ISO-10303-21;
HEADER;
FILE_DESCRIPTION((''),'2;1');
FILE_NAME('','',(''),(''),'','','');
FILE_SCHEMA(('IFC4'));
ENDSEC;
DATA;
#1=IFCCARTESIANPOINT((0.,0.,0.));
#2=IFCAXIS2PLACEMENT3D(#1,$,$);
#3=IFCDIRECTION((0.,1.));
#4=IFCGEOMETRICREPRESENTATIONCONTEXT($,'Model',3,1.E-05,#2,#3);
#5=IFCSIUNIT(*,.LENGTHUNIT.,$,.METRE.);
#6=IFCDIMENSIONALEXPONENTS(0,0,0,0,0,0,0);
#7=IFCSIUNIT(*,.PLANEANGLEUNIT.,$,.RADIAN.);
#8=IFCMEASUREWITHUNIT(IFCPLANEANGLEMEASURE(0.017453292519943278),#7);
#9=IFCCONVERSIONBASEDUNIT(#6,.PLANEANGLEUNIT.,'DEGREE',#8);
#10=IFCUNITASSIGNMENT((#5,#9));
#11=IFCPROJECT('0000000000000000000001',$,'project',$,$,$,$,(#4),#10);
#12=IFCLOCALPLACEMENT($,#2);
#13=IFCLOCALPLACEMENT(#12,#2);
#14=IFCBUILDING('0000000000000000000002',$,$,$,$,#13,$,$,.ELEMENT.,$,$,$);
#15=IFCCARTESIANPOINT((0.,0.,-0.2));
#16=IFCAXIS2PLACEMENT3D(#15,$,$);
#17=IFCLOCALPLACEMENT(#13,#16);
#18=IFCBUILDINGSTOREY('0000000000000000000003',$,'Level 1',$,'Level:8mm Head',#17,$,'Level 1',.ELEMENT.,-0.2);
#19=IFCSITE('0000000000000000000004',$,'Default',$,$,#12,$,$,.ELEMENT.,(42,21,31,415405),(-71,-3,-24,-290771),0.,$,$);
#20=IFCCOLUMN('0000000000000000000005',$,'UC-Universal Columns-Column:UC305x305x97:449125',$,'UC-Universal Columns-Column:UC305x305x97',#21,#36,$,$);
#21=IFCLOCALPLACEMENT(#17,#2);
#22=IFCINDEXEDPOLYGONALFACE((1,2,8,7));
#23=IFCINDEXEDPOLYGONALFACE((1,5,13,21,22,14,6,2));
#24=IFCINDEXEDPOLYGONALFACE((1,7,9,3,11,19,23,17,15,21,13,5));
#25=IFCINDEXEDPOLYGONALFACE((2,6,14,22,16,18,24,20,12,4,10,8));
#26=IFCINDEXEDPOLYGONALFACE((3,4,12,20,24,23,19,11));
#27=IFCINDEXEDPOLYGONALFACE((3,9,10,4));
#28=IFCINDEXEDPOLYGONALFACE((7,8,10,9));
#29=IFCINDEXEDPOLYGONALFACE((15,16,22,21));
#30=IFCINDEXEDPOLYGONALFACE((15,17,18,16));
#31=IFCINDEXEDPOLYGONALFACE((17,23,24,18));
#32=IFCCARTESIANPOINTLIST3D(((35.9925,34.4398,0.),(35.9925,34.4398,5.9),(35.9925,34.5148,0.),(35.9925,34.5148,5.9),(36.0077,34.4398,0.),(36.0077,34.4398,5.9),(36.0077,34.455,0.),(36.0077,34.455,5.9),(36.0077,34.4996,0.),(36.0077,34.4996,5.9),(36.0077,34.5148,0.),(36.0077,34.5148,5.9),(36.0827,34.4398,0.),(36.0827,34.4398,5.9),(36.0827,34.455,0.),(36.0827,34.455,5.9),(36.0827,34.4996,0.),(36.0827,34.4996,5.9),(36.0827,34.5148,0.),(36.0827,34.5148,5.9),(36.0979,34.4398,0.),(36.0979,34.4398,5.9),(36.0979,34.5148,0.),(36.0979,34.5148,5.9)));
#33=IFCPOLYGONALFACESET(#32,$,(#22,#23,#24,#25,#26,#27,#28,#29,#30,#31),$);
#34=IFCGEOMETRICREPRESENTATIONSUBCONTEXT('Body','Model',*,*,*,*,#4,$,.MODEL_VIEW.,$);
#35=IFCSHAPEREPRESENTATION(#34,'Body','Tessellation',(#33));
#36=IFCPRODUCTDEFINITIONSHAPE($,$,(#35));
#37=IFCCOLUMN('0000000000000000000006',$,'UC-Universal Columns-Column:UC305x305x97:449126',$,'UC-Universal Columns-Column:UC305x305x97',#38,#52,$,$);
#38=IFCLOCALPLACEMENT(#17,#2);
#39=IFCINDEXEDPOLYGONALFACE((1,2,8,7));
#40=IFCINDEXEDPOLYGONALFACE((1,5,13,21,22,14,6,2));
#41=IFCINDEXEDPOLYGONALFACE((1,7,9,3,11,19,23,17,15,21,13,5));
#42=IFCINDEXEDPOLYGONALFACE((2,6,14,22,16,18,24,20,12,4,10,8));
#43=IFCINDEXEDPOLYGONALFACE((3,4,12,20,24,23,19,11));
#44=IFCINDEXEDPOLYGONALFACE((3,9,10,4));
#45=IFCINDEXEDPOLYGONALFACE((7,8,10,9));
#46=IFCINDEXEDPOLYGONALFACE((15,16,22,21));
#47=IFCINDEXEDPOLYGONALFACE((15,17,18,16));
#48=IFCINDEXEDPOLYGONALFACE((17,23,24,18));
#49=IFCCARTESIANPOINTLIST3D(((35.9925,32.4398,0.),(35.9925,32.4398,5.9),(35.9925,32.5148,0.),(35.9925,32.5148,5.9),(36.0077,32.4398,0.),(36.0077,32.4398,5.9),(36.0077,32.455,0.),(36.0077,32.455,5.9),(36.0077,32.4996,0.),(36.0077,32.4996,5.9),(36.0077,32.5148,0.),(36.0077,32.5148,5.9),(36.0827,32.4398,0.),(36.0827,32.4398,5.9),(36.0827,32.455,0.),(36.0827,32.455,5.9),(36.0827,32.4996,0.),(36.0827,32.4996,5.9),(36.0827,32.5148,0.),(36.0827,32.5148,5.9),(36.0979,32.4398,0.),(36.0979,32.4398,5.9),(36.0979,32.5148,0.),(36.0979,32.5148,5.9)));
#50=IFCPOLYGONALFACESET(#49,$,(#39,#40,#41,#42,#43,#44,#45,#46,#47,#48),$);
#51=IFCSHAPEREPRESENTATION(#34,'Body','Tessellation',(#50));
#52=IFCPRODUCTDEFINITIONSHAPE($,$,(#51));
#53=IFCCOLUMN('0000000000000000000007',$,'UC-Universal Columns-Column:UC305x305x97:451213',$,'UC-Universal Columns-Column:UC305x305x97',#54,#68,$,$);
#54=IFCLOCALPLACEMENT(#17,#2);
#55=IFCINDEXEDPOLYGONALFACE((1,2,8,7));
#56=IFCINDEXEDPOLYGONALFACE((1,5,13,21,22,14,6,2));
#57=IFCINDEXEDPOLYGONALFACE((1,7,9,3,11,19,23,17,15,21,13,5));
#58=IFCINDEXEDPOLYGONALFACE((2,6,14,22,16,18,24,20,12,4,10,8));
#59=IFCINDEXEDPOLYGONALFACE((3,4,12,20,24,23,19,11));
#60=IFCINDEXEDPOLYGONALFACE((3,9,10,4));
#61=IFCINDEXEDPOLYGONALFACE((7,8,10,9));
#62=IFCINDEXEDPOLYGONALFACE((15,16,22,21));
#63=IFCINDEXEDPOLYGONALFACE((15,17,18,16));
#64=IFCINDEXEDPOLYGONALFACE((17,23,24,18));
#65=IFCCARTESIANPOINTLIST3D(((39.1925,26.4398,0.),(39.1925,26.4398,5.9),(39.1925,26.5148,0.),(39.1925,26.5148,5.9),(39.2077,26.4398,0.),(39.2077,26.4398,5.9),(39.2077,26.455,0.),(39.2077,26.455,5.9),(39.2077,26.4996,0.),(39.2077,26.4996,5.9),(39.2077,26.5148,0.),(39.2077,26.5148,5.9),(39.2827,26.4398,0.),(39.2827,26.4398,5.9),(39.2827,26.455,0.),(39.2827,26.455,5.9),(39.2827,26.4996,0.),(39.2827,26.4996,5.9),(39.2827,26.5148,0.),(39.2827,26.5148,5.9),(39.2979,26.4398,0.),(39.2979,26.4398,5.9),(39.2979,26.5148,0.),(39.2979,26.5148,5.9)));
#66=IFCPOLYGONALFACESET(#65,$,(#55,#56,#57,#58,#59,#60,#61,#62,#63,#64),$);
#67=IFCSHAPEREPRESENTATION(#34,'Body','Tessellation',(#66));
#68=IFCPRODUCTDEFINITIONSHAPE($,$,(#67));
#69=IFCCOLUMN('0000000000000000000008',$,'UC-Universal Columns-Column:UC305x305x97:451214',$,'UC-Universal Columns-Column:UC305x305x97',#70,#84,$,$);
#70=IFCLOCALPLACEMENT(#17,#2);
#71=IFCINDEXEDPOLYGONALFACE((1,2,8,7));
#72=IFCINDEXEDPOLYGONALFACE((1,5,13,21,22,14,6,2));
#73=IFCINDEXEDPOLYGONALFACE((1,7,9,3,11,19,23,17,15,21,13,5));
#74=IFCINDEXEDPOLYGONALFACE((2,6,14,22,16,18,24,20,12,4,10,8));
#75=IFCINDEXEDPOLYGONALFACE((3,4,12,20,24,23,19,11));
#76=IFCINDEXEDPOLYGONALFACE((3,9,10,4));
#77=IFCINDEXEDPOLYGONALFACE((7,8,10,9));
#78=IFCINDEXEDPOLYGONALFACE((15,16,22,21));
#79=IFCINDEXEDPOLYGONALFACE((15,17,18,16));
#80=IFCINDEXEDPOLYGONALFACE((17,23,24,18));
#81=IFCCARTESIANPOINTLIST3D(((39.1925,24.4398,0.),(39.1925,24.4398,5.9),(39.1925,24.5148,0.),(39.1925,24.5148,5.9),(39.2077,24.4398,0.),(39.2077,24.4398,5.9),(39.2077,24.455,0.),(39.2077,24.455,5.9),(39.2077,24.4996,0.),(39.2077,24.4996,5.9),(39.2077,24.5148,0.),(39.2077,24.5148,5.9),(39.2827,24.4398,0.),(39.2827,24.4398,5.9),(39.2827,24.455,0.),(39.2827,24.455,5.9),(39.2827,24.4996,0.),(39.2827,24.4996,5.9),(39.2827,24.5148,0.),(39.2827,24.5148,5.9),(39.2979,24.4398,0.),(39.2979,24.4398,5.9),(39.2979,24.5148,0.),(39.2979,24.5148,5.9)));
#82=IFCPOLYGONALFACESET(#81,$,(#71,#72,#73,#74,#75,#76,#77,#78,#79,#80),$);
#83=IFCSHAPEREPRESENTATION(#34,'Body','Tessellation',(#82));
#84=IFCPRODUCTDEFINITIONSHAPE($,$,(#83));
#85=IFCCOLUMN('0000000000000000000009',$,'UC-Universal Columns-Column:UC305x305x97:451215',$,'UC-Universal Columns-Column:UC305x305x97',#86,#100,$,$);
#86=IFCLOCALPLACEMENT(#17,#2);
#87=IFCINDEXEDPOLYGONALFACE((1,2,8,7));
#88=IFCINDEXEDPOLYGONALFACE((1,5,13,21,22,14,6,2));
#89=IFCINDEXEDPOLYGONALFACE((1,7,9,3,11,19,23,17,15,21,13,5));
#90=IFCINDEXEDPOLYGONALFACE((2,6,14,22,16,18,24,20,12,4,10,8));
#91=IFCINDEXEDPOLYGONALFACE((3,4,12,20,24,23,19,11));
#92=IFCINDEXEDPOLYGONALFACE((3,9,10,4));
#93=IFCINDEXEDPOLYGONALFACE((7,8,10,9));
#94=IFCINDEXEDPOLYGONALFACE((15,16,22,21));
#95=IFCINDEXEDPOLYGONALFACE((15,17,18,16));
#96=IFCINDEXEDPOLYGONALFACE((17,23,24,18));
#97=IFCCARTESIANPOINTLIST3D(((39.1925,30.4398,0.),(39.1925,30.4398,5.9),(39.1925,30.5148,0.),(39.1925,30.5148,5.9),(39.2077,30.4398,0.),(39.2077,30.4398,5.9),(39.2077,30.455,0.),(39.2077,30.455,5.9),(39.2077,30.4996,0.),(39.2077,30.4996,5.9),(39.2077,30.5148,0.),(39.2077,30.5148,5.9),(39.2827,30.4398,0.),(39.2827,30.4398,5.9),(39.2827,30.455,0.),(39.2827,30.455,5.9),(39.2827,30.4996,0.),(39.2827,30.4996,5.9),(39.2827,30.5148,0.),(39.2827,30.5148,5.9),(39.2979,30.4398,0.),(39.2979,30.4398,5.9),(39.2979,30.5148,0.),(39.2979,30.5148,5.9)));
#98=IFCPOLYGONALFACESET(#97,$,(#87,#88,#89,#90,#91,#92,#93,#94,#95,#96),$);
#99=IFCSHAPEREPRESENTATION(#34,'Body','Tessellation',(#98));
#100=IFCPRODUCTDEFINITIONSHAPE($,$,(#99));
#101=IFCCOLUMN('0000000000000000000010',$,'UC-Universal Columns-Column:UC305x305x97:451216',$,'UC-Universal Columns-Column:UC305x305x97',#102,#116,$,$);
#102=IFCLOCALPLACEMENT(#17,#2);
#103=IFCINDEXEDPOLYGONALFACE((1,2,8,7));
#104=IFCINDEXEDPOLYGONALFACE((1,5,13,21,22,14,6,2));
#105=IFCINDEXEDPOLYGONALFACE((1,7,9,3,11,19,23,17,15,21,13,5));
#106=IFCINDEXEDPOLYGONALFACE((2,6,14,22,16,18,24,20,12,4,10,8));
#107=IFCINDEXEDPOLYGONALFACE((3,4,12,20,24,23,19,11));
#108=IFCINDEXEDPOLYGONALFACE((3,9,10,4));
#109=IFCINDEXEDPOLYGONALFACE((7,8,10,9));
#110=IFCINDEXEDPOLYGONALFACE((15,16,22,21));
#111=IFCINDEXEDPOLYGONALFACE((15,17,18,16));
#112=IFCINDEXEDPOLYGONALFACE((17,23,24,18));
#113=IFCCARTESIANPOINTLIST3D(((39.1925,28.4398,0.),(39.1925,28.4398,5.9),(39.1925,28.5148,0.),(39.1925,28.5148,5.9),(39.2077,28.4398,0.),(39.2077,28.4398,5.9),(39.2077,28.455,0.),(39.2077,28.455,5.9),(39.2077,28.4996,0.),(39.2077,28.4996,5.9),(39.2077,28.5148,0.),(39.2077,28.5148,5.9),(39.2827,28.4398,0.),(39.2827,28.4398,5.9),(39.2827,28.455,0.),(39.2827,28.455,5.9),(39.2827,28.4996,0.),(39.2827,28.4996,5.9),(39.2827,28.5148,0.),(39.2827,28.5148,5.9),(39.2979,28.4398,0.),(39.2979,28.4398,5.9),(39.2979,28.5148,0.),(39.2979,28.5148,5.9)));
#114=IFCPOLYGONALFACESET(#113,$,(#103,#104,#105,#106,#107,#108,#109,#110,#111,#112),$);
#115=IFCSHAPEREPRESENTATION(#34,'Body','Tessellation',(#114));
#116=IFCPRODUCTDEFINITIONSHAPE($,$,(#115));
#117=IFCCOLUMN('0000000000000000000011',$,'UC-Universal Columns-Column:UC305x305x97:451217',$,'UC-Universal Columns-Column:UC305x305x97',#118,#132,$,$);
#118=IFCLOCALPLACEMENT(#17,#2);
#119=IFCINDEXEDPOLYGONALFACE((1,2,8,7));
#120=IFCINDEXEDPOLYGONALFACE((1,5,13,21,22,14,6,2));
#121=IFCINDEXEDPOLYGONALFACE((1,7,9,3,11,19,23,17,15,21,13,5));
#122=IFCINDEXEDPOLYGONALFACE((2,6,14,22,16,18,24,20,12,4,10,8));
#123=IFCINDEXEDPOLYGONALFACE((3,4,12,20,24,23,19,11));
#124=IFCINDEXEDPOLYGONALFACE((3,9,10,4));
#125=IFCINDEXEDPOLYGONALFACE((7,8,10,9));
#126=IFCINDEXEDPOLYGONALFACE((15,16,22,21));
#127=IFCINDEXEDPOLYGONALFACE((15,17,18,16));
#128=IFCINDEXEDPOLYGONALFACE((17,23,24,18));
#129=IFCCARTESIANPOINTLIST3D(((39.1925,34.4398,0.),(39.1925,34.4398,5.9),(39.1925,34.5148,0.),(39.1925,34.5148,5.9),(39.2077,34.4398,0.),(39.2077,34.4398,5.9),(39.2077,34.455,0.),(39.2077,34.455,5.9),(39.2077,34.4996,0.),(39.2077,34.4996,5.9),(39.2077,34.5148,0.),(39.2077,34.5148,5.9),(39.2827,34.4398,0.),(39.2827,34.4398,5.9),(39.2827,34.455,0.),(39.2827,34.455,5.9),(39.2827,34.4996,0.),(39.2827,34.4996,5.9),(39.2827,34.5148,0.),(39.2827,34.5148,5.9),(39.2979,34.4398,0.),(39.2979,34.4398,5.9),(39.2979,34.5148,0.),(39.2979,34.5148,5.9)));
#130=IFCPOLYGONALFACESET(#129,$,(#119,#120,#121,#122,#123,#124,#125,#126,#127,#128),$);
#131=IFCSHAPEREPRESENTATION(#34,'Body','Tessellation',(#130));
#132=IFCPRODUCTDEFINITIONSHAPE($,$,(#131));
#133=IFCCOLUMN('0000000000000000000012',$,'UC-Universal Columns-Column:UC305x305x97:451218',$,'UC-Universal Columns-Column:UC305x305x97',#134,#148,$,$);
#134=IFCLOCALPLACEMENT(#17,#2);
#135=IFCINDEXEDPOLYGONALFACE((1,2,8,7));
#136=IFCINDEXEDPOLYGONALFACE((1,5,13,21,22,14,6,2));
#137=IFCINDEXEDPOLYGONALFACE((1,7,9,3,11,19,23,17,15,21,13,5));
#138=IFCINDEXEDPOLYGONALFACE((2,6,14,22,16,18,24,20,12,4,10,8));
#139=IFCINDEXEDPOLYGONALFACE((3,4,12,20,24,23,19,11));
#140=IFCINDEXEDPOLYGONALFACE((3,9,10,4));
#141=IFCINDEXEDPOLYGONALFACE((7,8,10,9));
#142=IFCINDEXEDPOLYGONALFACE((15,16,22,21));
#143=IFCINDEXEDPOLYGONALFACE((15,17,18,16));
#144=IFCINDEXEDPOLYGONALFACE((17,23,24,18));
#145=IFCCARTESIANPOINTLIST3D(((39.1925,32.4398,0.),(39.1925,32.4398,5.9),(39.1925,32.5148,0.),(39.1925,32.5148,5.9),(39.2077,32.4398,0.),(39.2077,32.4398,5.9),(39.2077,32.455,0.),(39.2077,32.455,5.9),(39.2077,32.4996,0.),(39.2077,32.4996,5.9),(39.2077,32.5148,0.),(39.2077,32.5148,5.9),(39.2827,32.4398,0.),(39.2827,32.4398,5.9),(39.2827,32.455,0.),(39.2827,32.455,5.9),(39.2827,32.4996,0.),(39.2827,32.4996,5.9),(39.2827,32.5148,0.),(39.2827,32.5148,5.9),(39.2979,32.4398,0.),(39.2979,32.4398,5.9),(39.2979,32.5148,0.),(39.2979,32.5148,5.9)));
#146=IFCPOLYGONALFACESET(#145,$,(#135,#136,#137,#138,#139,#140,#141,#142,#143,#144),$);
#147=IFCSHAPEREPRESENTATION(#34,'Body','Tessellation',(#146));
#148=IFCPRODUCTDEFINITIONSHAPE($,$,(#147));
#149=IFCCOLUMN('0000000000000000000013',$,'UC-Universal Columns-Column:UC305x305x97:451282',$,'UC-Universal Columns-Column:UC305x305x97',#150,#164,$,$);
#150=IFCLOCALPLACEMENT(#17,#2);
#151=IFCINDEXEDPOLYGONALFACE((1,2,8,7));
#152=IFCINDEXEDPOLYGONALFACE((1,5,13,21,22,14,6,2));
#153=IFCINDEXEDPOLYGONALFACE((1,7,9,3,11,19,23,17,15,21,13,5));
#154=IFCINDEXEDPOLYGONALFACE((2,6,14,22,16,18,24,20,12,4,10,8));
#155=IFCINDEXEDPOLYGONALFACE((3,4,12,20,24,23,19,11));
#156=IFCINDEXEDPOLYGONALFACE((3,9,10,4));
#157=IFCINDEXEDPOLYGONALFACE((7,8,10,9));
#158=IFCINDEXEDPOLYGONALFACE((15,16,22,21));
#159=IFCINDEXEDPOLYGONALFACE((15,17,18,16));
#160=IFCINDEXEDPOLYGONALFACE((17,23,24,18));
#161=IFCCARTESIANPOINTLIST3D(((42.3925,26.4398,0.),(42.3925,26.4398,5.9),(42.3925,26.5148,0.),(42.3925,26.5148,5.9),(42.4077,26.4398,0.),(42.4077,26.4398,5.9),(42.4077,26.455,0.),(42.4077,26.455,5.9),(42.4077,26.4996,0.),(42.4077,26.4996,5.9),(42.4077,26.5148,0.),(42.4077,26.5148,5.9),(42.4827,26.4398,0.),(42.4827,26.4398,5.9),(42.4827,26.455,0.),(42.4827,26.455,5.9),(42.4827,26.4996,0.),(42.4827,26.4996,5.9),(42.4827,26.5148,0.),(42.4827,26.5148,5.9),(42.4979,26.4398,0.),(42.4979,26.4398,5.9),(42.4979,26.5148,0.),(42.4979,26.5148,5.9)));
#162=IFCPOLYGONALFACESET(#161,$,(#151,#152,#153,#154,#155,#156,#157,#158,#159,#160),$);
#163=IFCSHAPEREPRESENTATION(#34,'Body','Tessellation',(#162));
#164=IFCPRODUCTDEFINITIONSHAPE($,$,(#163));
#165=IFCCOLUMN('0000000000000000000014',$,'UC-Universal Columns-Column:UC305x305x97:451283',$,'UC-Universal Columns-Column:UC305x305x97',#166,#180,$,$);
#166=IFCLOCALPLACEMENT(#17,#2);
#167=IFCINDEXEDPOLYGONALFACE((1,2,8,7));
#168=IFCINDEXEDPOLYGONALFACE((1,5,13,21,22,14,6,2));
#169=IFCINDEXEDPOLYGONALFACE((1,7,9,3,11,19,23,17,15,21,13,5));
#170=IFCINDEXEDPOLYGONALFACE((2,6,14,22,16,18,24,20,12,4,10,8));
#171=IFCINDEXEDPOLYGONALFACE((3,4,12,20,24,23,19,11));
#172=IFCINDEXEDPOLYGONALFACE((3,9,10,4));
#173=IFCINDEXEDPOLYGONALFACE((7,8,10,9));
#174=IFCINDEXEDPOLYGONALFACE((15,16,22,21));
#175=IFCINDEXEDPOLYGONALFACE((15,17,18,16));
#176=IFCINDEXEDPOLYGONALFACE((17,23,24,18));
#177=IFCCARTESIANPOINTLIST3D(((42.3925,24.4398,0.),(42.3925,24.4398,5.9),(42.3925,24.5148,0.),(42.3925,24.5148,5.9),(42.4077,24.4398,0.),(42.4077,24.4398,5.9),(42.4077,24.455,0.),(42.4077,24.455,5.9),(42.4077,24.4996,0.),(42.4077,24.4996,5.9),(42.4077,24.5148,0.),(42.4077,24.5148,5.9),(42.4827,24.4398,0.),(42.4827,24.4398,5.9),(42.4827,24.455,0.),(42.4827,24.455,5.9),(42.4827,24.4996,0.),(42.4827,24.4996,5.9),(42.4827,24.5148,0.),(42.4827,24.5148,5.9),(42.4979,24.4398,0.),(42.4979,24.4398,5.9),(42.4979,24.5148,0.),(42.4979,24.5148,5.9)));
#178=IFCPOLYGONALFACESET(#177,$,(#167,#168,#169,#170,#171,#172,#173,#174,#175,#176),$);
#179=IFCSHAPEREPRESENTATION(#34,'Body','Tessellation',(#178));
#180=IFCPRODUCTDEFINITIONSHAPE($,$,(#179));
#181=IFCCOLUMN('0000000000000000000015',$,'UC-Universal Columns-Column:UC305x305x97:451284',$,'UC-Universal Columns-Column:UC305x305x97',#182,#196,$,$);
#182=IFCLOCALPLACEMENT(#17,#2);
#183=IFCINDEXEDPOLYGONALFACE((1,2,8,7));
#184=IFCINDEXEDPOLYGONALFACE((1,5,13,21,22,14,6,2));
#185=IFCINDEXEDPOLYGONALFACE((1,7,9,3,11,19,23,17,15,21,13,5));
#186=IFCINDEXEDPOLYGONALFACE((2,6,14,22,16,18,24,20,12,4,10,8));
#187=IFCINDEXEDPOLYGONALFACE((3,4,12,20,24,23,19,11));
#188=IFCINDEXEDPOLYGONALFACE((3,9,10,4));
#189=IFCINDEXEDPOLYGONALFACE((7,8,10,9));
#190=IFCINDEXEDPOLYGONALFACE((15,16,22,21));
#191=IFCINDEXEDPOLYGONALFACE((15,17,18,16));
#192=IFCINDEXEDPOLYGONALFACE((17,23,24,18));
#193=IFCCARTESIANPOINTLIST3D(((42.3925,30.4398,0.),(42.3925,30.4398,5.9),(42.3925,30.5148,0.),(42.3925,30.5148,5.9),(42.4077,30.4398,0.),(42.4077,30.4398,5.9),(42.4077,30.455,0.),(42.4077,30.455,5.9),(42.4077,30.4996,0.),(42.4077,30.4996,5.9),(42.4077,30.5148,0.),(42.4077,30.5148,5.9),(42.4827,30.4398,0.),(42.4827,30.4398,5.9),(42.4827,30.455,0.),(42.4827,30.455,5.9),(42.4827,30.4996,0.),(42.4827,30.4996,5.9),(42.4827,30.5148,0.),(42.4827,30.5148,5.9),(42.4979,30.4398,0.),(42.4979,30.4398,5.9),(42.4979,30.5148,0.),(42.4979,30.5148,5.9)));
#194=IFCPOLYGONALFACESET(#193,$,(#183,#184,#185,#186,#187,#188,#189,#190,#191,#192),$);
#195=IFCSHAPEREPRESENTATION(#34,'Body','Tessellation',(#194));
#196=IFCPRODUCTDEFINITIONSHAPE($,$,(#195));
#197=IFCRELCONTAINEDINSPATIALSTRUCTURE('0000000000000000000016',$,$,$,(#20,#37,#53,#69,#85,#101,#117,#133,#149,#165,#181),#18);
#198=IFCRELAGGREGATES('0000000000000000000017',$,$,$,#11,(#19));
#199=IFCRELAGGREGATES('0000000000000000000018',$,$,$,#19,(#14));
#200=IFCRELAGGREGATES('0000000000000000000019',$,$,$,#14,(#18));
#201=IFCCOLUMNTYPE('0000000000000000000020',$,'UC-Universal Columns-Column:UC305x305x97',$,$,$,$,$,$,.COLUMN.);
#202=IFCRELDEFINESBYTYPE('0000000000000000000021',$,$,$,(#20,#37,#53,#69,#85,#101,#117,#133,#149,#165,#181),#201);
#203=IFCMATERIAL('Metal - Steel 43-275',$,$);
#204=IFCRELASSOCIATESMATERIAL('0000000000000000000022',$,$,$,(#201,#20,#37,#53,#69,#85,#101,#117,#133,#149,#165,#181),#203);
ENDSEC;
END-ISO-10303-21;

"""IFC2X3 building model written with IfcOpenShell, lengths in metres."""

from ifc_helpers import new_model, entity, si_unit, converted_unit, direction, frame, frame_2d, origin, place, context, subcontext, project, spatial, polyline, circle_curve, parameter, trimmed, segment, composite_curve, outline, extrude, source, transform, mapped, material, type_object, type_shapes, element, save


model = new_model("IFC2X3")

# Units and contexts
model_context = context("Model", 3, precision=1e-05, world=origin(), true_north=direction((0.0, 1.0)))
body_context = subcontext(model_context, "Body", "Model", "MODEL_VIEW")
ifc_project = project(units=[si_unit("LENGTHUNIT", "METRE"), converted_unit("PLANEANGLEUNIT", "DEGREE", entity("IfcPlaneAngleMeasure", 0.017453292519943278), si_unit("PLANEANGLEUNIT", "RADIAN"), dimensions=[0, 0, 0, 0, 0, 0, 0])], contexts=[model_context])

# Site, building, storey
site_placement = place(None, origin())
site = spatial("IfcSite", under=ifc_project, at=site_placement, Name="Default", CompositionType="ELEMENT", RefLatitude=(42, 21, 31, 415405), RefLongitude=(-71, -3, -24, -290771), RefElevation=0.0)
building_placement = place(site_placement, origin())
building = spatial("IfcBuilding", under=site, at=building_placement, CompositionType="ELEMENT")
storey_placement = place(building_placement, frame((0.0, 0.0, -0.2)))
storey = spatial("IfcBuildingStorey", under=building, at=storey_placement, Name="Level 1", ObjectType="Level:8mm Head", LongName="Level 1", CompositionType="ELEMENT", Elevation=-0.2)

# Columns
ifc_material = material(Name="Metal - Steel 43-275")
column_type = type_object("IfcColumnType", Name="UC-Universal Columns-Column:UC305x305x97", PredefinedType="COLUMN", material=ifc_material)
shared_shape = source(origin(), body_context, "Body", "SweptSolid", [
    extrude(outline(composite_curve([segment(polyline([(-0.0375, -0.0375), (0.0375, -0.0375)]), True, "CONTINUOUS"), segment(polyline([(0.0375, -0.0375), (0.0527, -0.0375)]), True, "CONTINUOUS"), segment(trimmed(circle_curve(frame_2d((0.0527, -0.0223), x_axis=(-1.0, 0.0)), 0.0152), [parameter(0.0)], [parameter(90.0)], True, "PARAMETER"), False, "CONTINUOUS"), segment(polyline([(0.0375, -0.0223), (0.0375, 0.0223)]), True, "CONTINUOUS"), segment(trimmed(circle_curve(frame_2d((0.0527, 0.0223), x_axis=(-1.0, 0.0)), 0.0152), [parameter(270.0)], [parameter(0.0)], True, "PARAMETER"), False, "CONTINUOUS"), segment(polyline([(0.0527, 0.0375), (0.0375, 0.0375)]), True, "CONTINUOUS"), segment(polyline([(0.0375, 0.0375), (-0.0375, 0.0375)]), True, "CONTINUOUS"), segment(polyline([(-0.0375, 0.0375), (-0.0527, 0.0375)]), True, "CONTINUOUS"), segment(trimmed(circle_curve(frame_2d((-0.0527, 0.0223), x_axis=(-1.0, 0.0)), 0.0152), [parameter(180.0)], [parameter(270.0)], True, "PARAMETER"), False, "CONTINUOUS"), segment(polyline([(-0.0375, 0.0223), (-0.0375, -0.0223)]), True, "CONTINUOUS"), segment(trimmed(circle_curve(frame_2d((-0.0527, -0.0223), x_axis=(-1.0, 0.0)), 0.0152), [parameter(90.0)], [parameter(180.0)], True, "PARAMETER"), False, "CONTINUOUS"), segment(polyline([(-0.0527, -0.0375), (-0.0375, -0.0375)]), True, "CONTINUOUS")], self_intersect=False)), frame((0.0, 0.0, -0.2), z_axis=(0.0, 0.0, 1.0), x_axis=(-1.0, 0.0, 0.0)), (0.0, 0.0, 1.0), 5.9),
])
type_shapes(column_type, [shared_shape])
for number, where, z_axis, x_axis, name in (
    (1, (36.0452, 34.4773, 0.2), (0.0, 0.0, 1.0), (-1.0, 0.0, 0.0), "UC-Universal Columns-Column:UC305x305x97:449125"),
    (2, (36.0452, 32.4773, 0.2), (0.0, 0.0, 1.0), (-1.0, 0.0, 0.0), "UC-Universal Columns-Column:UC305x305x97:449126"),
    (3, (39.2452, 26.4773, 0.2), (0.0, 0.0, 1.0), (-1.0, 0.0, 0.0), "UC-Universal Columns-Column:UC305x305x97:451213"),
    (4, (39.2452, 24.4773, 0.2), (0.0, 0.0, 1.0), (-1.0, 0.0, 0.0), "UC-Universal Columns-Column:UC305x305x97:451214"),
    (5, (39.2452, 30.4773, 0.2), (0.0, 0.0, 1.0), (-1.0, 0.0, 0.0), "UC-Universal Columns-Column:UC305x305x97:451215"),
    (6, (39.2452, 28.4773, 0.2), (0.0, 0.0, 1.0), (-1.0, 0.0, 0.0), "UC-Universal Columns-Column:UC305x305x97:451216"),
    (7, (39.2452, 34.4773, 0.2), (0.0, 0.0, 1.0), (-1.0, 0.0, 0.0), "UC-Universal Columns-Column:UC305x305x97:451217"),
    (8, (39.2452, 32.4773, 0.2), (0.0, 0.0, 1.0), (-1.0, 0.0, 0.0), "UC-Universal Columns-Column:UC305x305x97:451218"),
    (9, (42.4452, 26.4773, 0.2), (0.0, 0.0, 1.0), (-1.0, 0.0, 0.0), "UC-Universal Columns-Column:UC305x305x97:451282"),
    (10, (42.4452, 24.4773, 0.2), (0.0, 0.0, 1.0), (-1.0, 0.0, 0.0), "UC-Universal Columns-Column:UC305x305x97:451283"),
    (11, (42.4452, 30.4773, 0.2), (0.0, 0.0, 1.0), (-1.0, 0.0, 0.0), "UC-Universal Columns-Column:UC305x305x97:451284"),
):
    element("IfcColumn", number, at=place(storey_placement, frame(where, z_axis=z_axis, x_axis=x_axis)), inside=storey, type_object=column_type, material=ifc_material, Name=name, ObjectType="UC-Universal Columns-Column:UC305x305x97", context=body_context, shape_type="MappedRepresentation", body=[
        mapped(shared_shape, transform((0.0, 0.0, 0.0), scale=1.0)),
    ])

save(model, "model.ifc")
